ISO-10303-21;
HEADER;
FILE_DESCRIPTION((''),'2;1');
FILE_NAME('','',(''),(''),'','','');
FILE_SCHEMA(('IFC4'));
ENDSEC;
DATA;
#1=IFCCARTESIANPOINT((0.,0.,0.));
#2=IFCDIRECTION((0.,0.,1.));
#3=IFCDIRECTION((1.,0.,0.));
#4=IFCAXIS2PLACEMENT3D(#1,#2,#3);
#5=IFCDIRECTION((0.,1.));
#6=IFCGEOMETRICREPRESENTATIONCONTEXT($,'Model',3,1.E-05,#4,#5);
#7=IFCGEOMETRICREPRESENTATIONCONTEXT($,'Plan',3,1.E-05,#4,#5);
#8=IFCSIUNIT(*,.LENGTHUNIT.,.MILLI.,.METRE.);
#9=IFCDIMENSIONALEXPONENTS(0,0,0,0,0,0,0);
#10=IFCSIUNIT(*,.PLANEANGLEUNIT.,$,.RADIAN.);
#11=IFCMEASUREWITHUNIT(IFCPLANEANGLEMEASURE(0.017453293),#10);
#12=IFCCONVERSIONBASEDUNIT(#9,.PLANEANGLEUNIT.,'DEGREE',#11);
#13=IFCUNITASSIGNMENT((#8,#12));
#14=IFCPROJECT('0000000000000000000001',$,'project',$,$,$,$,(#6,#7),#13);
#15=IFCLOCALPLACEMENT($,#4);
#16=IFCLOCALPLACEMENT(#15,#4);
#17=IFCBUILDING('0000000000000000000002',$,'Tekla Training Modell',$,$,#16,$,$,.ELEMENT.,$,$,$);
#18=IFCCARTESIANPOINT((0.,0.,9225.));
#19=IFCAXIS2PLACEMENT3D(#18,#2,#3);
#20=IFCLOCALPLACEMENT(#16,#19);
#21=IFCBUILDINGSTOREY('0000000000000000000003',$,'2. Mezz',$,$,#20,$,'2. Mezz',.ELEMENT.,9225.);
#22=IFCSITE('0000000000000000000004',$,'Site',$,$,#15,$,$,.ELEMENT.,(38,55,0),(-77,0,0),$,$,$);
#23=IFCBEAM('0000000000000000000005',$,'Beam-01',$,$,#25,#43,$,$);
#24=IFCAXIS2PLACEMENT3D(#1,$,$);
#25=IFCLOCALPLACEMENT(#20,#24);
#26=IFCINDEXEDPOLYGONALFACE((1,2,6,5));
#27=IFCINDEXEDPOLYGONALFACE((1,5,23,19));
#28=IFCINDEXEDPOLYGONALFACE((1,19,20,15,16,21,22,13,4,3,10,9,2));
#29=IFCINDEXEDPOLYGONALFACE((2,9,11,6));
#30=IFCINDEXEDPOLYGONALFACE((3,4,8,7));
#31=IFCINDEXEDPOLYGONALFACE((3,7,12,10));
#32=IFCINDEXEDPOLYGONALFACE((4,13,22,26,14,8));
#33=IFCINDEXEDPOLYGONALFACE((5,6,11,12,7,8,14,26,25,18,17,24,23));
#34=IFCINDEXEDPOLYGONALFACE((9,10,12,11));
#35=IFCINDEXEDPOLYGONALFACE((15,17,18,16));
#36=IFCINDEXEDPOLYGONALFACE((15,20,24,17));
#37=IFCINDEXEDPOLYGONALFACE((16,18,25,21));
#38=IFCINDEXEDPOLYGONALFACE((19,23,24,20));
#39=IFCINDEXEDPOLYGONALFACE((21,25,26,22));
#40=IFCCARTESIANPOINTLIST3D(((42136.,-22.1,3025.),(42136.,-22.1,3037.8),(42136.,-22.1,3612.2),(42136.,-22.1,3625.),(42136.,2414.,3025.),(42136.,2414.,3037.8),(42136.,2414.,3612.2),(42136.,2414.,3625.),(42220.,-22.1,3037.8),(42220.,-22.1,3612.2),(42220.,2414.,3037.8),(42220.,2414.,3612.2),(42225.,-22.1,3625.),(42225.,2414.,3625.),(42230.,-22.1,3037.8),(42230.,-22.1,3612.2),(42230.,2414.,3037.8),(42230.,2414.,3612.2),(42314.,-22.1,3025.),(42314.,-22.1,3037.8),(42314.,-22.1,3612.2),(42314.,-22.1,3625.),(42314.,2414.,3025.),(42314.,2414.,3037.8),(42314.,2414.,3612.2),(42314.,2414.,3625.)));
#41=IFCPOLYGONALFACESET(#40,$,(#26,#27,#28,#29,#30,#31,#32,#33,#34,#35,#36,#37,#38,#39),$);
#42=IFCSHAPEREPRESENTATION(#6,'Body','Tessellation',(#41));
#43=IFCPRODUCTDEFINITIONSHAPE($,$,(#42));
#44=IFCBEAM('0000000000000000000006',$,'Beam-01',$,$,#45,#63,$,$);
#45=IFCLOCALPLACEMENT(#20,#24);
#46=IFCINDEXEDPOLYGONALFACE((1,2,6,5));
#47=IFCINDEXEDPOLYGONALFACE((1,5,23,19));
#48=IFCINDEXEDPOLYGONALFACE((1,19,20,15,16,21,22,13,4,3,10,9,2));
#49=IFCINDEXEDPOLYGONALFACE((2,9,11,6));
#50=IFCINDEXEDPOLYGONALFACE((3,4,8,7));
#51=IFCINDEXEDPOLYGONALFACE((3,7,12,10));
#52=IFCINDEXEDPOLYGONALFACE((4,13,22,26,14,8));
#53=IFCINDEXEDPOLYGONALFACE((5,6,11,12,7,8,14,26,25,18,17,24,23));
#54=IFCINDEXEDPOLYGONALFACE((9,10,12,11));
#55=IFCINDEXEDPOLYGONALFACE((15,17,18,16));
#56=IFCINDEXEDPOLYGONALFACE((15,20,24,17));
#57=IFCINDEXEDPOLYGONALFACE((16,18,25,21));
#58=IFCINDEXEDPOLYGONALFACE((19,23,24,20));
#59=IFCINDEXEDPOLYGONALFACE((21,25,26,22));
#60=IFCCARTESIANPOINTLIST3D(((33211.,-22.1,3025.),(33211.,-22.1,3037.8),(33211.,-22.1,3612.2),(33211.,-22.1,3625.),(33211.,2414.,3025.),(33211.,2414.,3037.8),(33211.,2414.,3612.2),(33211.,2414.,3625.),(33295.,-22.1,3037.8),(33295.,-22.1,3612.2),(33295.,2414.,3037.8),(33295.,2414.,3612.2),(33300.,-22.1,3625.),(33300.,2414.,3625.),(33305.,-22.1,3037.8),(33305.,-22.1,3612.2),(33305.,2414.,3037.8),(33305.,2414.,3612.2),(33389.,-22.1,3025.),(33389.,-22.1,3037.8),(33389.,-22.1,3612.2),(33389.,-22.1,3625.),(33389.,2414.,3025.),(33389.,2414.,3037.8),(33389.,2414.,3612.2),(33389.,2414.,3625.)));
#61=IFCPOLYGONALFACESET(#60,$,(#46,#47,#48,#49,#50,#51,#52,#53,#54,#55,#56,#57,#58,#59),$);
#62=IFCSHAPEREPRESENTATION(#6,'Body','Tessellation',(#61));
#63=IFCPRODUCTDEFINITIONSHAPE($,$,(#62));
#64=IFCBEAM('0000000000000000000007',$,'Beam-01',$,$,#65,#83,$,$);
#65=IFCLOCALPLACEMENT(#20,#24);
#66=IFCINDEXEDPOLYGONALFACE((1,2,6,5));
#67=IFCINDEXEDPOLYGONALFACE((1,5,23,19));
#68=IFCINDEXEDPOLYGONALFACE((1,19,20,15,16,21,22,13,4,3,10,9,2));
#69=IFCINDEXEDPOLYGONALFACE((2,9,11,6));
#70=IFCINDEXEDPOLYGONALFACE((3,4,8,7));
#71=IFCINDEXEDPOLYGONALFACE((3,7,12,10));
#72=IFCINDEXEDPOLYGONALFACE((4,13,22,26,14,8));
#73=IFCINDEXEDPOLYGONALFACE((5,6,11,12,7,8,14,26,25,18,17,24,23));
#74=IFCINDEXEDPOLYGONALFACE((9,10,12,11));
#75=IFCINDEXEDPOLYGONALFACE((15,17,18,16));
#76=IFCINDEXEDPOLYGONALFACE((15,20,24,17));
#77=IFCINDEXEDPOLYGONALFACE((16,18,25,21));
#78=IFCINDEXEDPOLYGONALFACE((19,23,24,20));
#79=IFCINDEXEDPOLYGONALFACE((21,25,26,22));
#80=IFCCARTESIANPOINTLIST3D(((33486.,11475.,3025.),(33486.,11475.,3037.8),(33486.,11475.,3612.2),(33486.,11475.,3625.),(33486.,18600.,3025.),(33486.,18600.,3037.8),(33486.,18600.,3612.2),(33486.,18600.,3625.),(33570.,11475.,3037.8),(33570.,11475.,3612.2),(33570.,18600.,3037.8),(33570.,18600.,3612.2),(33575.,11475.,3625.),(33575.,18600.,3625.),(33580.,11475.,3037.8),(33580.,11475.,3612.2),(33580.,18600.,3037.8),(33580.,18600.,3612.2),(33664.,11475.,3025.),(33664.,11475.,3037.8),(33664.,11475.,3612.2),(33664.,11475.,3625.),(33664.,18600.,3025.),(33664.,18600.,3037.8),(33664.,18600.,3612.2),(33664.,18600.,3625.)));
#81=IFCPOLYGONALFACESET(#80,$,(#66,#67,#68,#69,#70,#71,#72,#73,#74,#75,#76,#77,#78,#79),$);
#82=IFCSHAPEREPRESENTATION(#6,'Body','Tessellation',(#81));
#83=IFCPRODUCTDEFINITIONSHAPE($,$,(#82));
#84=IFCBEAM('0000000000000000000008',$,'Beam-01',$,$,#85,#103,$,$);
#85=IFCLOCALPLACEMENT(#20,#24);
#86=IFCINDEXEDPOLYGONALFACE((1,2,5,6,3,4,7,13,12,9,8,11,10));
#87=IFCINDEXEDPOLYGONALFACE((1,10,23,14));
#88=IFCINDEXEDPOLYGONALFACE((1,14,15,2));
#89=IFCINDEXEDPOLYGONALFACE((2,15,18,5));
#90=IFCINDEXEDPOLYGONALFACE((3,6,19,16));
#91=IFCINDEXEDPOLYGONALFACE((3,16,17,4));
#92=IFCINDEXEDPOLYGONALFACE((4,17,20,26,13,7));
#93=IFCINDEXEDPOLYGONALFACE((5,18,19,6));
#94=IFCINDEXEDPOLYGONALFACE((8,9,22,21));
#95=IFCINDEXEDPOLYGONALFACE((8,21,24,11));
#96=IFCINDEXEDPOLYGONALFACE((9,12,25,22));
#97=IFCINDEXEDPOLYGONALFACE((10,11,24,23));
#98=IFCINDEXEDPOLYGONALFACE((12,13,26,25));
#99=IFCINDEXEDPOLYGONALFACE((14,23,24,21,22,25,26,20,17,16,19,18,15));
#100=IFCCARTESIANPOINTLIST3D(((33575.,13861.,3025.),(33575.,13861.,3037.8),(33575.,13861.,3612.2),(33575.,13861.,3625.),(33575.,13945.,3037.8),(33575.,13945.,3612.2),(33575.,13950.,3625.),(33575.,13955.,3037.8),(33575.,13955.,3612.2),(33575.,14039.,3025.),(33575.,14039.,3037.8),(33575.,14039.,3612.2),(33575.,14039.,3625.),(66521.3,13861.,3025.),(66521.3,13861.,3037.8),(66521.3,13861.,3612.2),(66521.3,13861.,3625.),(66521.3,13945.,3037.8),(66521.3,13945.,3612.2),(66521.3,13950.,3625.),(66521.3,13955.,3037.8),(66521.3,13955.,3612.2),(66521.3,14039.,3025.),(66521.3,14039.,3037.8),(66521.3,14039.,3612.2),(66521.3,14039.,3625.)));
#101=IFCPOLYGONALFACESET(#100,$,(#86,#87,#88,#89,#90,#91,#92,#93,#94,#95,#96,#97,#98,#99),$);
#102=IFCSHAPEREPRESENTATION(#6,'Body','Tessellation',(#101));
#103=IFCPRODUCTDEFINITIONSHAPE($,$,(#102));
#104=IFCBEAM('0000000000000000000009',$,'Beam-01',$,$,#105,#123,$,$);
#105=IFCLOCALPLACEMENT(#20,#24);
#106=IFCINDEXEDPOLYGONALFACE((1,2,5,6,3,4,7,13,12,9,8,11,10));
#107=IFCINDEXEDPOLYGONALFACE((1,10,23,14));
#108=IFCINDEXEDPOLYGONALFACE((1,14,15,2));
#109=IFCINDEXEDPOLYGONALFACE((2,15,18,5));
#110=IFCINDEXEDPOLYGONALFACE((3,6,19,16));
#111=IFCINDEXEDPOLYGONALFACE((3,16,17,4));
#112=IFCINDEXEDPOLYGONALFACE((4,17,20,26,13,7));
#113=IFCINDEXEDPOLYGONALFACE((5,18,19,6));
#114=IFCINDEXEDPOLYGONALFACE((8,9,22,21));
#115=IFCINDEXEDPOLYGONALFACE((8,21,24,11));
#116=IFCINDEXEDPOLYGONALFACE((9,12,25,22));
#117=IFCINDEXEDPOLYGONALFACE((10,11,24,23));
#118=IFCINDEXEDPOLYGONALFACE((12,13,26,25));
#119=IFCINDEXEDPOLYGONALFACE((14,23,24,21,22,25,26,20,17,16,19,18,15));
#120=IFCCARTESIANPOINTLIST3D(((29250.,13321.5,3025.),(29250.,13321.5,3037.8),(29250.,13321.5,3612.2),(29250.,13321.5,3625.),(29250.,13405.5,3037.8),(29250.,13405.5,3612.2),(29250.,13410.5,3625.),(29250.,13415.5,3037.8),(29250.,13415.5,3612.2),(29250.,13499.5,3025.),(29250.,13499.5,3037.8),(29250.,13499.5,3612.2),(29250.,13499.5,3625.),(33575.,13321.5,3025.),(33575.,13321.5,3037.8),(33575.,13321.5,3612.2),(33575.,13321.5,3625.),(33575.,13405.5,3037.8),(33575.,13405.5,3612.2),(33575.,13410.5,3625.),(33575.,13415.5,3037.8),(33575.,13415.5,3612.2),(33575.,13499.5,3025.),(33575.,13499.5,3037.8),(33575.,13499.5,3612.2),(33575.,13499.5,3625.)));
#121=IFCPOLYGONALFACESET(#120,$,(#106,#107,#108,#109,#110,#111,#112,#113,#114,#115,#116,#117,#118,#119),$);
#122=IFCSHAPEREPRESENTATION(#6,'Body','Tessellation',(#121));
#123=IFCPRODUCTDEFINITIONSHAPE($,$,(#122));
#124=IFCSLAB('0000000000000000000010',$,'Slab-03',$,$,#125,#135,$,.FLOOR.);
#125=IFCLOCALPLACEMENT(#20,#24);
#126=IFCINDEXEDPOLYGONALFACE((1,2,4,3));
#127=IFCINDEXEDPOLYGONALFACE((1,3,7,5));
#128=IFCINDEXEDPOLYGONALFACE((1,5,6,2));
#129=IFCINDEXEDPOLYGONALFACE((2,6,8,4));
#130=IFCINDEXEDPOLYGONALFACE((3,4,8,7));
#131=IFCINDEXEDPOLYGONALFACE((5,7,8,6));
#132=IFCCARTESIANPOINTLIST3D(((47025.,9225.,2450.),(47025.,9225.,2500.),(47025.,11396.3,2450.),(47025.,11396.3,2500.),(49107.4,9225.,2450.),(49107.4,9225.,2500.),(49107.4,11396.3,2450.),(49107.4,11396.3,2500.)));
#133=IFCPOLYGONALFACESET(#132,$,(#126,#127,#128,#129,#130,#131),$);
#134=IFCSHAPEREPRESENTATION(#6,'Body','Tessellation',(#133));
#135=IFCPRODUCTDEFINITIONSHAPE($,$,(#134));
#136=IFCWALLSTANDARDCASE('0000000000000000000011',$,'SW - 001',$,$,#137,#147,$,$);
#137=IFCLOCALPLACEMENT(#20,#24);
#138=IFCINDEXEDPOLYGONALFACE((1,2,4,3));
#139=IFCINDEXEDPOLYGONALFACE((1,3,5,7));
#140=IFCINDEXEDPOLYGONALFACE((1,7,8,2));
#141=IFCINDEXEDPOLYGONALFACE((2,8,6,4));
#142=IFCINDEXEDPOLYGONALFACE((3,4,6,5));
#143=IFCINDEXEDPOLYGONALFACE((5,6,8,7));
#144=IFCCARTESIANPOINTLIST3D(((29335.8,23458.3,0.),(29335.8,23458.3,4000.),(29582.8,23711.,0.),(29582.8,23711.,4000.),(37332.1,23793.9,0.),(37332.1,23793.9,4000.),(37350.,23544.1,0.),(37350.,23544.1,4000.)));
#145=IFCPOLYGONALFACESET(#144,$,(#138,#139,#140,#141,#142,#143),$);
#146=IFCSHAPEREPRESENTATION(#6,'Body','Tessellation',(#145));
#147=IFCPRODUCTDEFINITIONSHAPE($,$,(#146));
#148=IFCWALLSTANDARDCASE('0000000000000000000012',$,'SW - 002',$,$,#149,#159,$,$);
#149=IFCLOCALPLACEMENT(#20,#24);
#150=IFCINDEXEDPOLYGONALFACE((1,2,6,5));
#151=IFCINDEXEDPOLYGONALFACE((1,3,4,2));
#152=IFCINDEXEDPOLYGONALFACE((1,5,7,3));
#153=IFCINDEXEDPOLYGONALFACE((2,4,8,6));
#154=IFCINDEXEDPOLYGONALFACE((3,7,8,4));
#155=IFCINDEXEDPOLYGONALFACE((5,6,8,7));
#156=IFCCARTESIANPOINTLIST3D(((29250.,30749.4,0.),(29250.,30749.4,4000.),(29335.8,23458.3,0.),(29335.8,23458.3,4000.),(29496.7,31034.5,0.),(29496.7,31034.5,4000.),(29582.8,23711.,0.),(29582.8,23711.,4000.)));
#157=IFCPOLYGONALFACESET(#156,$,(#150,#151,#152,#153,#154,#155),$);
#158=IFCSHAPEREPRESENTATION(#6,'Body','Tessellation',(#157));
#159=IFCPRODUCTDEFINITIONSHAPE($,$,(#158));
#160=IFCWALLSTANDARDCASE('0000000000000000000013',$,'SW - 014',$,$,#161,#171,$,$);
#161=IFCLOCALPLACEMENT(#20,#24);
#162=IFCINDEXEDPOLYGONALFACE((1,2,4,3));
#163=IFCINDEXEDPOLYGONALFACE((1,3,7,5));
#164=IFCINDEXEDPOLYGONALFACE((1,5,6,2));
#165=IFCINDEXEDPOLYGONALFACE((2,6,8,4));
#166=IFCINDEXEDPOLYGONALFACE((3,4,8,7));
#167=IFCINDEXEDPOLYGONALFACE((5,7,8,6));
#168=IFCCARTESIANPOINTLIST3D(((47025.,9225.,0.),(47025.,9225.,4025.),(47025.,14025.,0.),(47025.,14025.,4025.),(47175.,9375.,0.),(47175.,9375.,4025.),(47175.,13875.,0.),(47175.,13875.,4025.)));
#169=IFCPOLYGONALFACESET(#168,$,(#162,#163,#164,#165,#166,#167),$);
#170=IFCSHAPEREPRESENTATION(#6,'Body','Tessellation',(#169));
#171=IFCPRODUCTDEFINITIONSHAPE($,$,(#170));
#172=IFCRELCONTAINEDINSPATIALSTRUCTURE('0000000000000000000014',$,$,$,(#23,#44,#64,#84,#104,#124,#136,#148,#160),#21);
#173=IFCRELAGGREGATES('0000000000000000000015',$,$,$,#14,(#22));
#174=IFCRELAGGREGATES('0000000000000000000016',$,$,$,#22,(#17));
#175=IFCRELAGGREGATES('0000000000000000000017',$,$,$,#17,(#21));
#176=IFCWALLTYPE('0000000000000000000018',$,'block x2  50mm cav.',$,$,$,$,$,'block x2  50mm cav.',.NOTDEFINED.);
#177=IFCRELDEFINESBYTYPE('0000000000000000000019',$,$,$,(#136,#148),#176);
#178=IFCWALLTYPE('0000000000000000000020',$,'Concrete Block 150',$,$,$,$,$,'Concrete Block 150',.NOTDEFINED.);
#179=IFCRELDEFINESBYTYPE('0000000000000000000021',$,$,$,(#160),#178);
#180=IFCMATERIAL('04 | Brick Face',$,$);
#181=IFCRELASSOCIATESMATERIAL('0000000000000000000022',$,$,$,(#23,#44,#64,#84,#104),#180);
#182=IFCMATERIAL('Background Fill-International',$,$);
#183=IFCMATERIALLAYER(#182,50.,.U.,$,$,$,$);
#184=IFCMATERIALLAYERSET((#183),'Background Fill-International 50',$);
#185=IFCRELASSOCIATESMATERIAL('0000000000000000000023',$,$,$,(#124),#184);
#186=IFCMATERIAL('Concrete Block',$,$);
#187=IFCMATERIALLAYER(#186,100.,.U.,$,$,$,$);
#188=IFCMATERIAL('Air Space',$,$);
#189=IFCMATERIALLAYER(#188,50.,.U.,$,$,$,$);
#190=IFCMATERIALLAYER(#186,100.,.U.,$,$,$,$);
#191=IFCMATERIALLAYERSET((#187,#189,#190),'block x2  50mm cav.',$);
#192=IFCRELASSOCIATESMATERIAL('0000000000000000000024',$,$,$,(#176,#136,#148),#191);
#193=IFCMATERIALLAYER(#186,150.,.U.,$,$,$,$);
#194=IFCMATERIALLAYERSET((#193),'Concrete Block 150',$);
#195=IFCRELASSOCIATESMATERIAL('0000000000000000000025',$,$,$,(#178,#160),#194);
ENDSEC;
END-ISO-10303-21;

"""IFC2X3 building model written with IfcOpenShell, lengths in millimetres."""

from ifc_helpers import new_model, entity, si_unit, converted_unit, direction, frame, origin_with_axes, place, context, project, spatial, polyline, outline, extrude, material, layer, layer_set, layer_usage, type_object, element, save


model = new_model("IFC2X3")

# Units and contexts
model_context = context("Model", 3, precision=1e-05, world=origin_with_axes(), true_north=direction((0.0, 1.0)))
plan_context = context("Plan", 3, precision=1e-05, world=origin_with_axes(), true_north=direction((0.0, 1.0)))
ifc_project = project(units=[si_unit("LENGTHUNIT", "METRE", prefix="MILLI"), converted_unit("PLANEANGLEUNIT", "DEGREE", entity("IfcPlaneAngleMeasure", 0.017453293), si_unit("PLANEANGLEUNIT", "RADIAN"), dimensions=[0, 0, 0, 0, 0, 0, 0])], contexts=[model_context, plan_context])

# Site, building, storey
site_placement = place(None, origin_with_axes())
site = spatial("IfcSite", under=ifc_project, at=site_placement, Name="Site", CompositionType="ELEMENT", RefLatitude=(38, 55, 0), RefLongitude=(-77, 0, 0))
building_placement = place(site_placement, origin_with_axes())
building = spatial("IfcBuilding", under=site, at=building_placement, Name="Tekla Training Modell", CompositionType="ELEMENT")
storey_placement = place(building_placement, frame((0.0, 0.0, 9225.0), z_axis=(0.0, 0.0, 1.0), x_axis=(1.0, 0.0, 0.0)))
storey = spatial("IfcBuildingStorey", under=building, at=storey_placement, Name="2. Mezz", LongName="2. Mezz", CompositionType="ELEMENT", Elevation=9225.0)

# Shared definitions
ifc_material_1 = material(Name="04 | Brick Face")

# Beams
for number, where, z_axis, x_axis, name in (
    (1, (42225.0, 2414.0, 3325.0), (0.0, 0.0, 1.0), (-1.0, 0.0, 0.0), "Beam-01"),
    (2, (33300.0, 2414.0, 3325.0), (0.0, 0.0, 1.0), (-1.0, 0.0, 0.0), "Beam-01"),
):
    element("IfcBeam", number, at=place(storey_placement, frame(where, z_axis=z_axis, x_axis=x_axis)), inside=storey, material=ifc_material_1, Name=name, context=model_context, shape_type="SweptSolid", body=[
        extrude(outline(polyline([(0.0, 300.0), (-89.0, 300.0), (-89.0, 287.2), (-5.0, 287.2), (-5.0, -287.2), (-89.0, -287.2), (-89.0, -300.0), (89.0, -300.0), (89.0, -287.2), (5.0, -287.2), (5.0, 287.2), (89.0, 287.2), (89.0, 300.0), (0.0, 300.0)])), frame((0.0, 2436.1, 0.0), z_axis=(0.0, -1.0, 0.0), x_axis=(1.0, 0.0, 0.0)), (0.0, 0.0, 1.0), 2436.1),
    ])
beam_1_placement = place(storey_placement, frame((33575.0, 18600.0, 3325.0), z_axis=(0.0, 0.0, 1.0), x_axis=(-1.0, 0.0, 0.0)))
element("IfcBeam", 3, at=beam_1_placement, inside=storey, material=ifc_material_1, Name="Beam-01", context=model_context, shape_type="SweptSolid", body=[
    extrude(outline(polyline([(0.0, 300.0), (-89.0, 300.0), (-89.0, 287.2), (-5.0, 287.2), (-5.0, -287.2), (-89.0, -287.2), (-89.0, -300.0), (89.0, -300.0), (89.0, -287.2), (5.0, -287.2), (5.0, 287.2), (89.0, 287.2), (89.0, 300.0), (0.0, 300.0)])), frame((0.0, 7125.0, 0.0), z_axis=(0.0, -1.0, 0.0), x_axis=(1.0, 0.0, 0.0)), (0.0, 0.0, 1.0), 7125.0),
])
beam_2_placement = place(storey_placement, frame((33575.0, 13950.0, 3325.0), z_axis=(0.0, 0.0, 1.0), x_axis=(0.0, -1.0, 0.0)))
element("IfcBeam", 4, at=beam_2_placement, inside=storey, material=ifc_material_1, Name="Beam-01", context=model_context, shape_type="SweptSolid", body=[
    extrude(outline(polyline([(0.0, 300.0), (-89.0, 300.0), (-89.0, 287.2), (-5.0, 287.2), (-5.0, -287.2), (-89.0, -287.2), (-89.0, -300.0), (89.0, -300.0), (89.0, -287.2), (5.0, -287.2), (5.0, 287.2), (89.0, 287.2), (89.0, 300.0), (0.0, 300.0)])), frame((0.0, 32946.3, 0.0), z_axis=(0.0, -1.0, 0.0), x_axis=(1.0, 0.0, 0.0)), (0.0, 0.0, 1.0), 32946.3),
])
beam_3_placement = place(storey_placement, frame((29250.0, 13410.5, 3325.0), z_axis=(0.0, 0.0, 1.0), x_axis=(0.0, -1.0, 0.0)))
element("IfcBeam", 5, at=beam_3_placement, inside=storey, material=ifc_material_1, Name="Beam-01", context=model_context, shape_type="SweptSolid", body=[
    extrude(outline(polyline([(0.0, 300.0), (-89.0, 300.0), (-89.0, 287.2), (-5.0, 287.2), (-5.0, -287.2), (-89.0, -287.2), (-89.0, -300.0), (89.0, -300.0), (89.0, -287.2), (5.0, -287.2), (5.0, 287.2), (89.0, 287.2), (89.0, 300.0), (0.0, 300.0)])), frame((0.0, 4325.0, 0.0), z_axis=(0.0, -1.0, 0.0), x_axis=(1.0, 0.0, 0.0)), (0.0, 0.0, 1.0), 4325.0),
])

# Slab
ifc_material_2 = material(Name="Background Fill-International")
ifc_layer_1 = layer(ifc_material_2, 50.0, ventilated="UNKNOWN")
ifc_layer_set_1 = layer_set([ifc_layer_1], Name="Background Fill-International 50")
ifc_layer_usage_1 = layer_usage(ifc_layer_set_1, "AXIS3", "NEGATIVE", 50.0)
slab_placement = place(storey_placement, frame((49107.4, 11396.3, 2450.0), z_axis=(0.0, 0.0, 1.0), x_axis=(-1.0, 0.0, 0.0)))
element("IfcSlab", 6, at=slab_placement, inside=storey, material=ifc_layer_usage_1, Name="Slab-03", PredefinedType="FLOOR", context=model_context, shape_type="SweptSolid", body=[
    extrude(outline(polyline([(0.0, 0.0), (2082.4, 0.0), (2082.4, 2171.3), (0.0, 2171.3), (0.0, 0.0)])), origin_with_axes(), (0.0, 0.0, 1.0), 50.0),
])

# Walls
ifc_material_3 = material(Name="Concrete Block")
ifc_layer_2 = layer(ifc_material_3, 100.0, ventilated="UNKNOWN")
ifc_material_4 = material(Name="Air Space")
ifc_layer_3 = layer(ifc_material_4, 50.0, ventilated="UNKNOWN")
ifc_layer_4 = layer(ifc_material_3, 100.0, ventilated="UNKNOWN")
ifc_layer_set_2 = layer_set([ifc_layer_2, ifc_layer_3, ifc_layer_4], Name="block x2  50mm cav.")
ifc_layer_usage_2 = layer_usage(ifc_layer_set_2, "AXIS2", "NEGATIVE", 0.0)
wall_type_1 = type_object("IfcWallType", Name="block x2  50mm cav.", ElementType="block x2  50mm cav.", PredefinedType="NOTDEFINED", material=ifc_layer_set_2)
wall_1_placement = place(storey_placement, frame((37350.0, 23544.1, 0.0), z_axis=(0.0, 0.0, 1.0), x_axis=(-0.999943, -0.010699, 0.0)))
element("IfcWallStandardCase", 7, at=wall_1_placement, inside=storey, type_object=wall_type_1, material=ifc_layer_usage_2, Name="SW - 001", context=model_context, shape_type="SweptSolid", body=[
    extrude(outline(polyline([(15.2, -250.0), (7765.0, -250.0), (8014.7, 0.0), (0.0, 0.0), (15.2, -250.0)])), origin_with_axes(), (0.0, 0.0, 1.0), 4000.0),
])
ifc_layer_usage_3 = layer_usage(ifc_layer_set_2, "AXIS2", "NEGATIVE", 0.0)
wall_2_placement = place(storey_placement, frame((29335.8, 23458.3, 0.0), z_axis=(0.0, 0.0, 1.0), x_axis=(-0.01176, 0.999931, 0.0)))
element("IfcWallStandardCase", 8, at=wall_2_placement, inside=storey, type_object=wall_type_1, material=ifc_layer_usage_3, Name="SW - 002", context=model_context, shape_type="SweptSolid", body=[
    extrude(outline(polyline([(249.7, -250.0), (7573.7, -250.0), (7291.5, 0.0), (0.0, 0.0), (249.7, -250.0)])), origin_with_axes(), (0.0, 0.0, 1.0), 4000.0),
])
ifc_layer_5 = layer(ifc_material_3, 150.0, ventilated="UNKNOWN")
ifc_layer_set_3 = layer_set([ifc_layer_5], Name="Concrete Block 150")
ifc_layer_usage_4 = layer_usage(ifc_layer_set_3, "AXIS2", "POSITIVE", -75.0)
wall_type_2 = type_object("IfcWallType", Name="Concrete Block 150", ElementType="Concrete Block 150", PredefinedType="NOTDEFINED", material=ifc_layer_set_3)
wall_3_placement = place(storey_placement, frame((47100.0, 13950.0, 0.0), z_axis=(0.0, 0.0, 1.0), x_axis=(0.0, -1.0, 0.0)))
element("IfcWallStandardCase", 9, at=wall_3_placement, inside=storey, type_object=wall_type_2, material=ifc_layer_usage_4, Name="SW - 014", context=model_context, shape_type="SweptSolid", body=[
    extrude(outline(polyline([(-75.0, -75.0), (4725.0, -75.0), (4575.0, 75.0), (75.0, 75.0), (-75.0, -75.0)])), origin_with_axes(), (0.0, 0.0, 1.0), 4025.0),
])

save(model, "model.ifc")
